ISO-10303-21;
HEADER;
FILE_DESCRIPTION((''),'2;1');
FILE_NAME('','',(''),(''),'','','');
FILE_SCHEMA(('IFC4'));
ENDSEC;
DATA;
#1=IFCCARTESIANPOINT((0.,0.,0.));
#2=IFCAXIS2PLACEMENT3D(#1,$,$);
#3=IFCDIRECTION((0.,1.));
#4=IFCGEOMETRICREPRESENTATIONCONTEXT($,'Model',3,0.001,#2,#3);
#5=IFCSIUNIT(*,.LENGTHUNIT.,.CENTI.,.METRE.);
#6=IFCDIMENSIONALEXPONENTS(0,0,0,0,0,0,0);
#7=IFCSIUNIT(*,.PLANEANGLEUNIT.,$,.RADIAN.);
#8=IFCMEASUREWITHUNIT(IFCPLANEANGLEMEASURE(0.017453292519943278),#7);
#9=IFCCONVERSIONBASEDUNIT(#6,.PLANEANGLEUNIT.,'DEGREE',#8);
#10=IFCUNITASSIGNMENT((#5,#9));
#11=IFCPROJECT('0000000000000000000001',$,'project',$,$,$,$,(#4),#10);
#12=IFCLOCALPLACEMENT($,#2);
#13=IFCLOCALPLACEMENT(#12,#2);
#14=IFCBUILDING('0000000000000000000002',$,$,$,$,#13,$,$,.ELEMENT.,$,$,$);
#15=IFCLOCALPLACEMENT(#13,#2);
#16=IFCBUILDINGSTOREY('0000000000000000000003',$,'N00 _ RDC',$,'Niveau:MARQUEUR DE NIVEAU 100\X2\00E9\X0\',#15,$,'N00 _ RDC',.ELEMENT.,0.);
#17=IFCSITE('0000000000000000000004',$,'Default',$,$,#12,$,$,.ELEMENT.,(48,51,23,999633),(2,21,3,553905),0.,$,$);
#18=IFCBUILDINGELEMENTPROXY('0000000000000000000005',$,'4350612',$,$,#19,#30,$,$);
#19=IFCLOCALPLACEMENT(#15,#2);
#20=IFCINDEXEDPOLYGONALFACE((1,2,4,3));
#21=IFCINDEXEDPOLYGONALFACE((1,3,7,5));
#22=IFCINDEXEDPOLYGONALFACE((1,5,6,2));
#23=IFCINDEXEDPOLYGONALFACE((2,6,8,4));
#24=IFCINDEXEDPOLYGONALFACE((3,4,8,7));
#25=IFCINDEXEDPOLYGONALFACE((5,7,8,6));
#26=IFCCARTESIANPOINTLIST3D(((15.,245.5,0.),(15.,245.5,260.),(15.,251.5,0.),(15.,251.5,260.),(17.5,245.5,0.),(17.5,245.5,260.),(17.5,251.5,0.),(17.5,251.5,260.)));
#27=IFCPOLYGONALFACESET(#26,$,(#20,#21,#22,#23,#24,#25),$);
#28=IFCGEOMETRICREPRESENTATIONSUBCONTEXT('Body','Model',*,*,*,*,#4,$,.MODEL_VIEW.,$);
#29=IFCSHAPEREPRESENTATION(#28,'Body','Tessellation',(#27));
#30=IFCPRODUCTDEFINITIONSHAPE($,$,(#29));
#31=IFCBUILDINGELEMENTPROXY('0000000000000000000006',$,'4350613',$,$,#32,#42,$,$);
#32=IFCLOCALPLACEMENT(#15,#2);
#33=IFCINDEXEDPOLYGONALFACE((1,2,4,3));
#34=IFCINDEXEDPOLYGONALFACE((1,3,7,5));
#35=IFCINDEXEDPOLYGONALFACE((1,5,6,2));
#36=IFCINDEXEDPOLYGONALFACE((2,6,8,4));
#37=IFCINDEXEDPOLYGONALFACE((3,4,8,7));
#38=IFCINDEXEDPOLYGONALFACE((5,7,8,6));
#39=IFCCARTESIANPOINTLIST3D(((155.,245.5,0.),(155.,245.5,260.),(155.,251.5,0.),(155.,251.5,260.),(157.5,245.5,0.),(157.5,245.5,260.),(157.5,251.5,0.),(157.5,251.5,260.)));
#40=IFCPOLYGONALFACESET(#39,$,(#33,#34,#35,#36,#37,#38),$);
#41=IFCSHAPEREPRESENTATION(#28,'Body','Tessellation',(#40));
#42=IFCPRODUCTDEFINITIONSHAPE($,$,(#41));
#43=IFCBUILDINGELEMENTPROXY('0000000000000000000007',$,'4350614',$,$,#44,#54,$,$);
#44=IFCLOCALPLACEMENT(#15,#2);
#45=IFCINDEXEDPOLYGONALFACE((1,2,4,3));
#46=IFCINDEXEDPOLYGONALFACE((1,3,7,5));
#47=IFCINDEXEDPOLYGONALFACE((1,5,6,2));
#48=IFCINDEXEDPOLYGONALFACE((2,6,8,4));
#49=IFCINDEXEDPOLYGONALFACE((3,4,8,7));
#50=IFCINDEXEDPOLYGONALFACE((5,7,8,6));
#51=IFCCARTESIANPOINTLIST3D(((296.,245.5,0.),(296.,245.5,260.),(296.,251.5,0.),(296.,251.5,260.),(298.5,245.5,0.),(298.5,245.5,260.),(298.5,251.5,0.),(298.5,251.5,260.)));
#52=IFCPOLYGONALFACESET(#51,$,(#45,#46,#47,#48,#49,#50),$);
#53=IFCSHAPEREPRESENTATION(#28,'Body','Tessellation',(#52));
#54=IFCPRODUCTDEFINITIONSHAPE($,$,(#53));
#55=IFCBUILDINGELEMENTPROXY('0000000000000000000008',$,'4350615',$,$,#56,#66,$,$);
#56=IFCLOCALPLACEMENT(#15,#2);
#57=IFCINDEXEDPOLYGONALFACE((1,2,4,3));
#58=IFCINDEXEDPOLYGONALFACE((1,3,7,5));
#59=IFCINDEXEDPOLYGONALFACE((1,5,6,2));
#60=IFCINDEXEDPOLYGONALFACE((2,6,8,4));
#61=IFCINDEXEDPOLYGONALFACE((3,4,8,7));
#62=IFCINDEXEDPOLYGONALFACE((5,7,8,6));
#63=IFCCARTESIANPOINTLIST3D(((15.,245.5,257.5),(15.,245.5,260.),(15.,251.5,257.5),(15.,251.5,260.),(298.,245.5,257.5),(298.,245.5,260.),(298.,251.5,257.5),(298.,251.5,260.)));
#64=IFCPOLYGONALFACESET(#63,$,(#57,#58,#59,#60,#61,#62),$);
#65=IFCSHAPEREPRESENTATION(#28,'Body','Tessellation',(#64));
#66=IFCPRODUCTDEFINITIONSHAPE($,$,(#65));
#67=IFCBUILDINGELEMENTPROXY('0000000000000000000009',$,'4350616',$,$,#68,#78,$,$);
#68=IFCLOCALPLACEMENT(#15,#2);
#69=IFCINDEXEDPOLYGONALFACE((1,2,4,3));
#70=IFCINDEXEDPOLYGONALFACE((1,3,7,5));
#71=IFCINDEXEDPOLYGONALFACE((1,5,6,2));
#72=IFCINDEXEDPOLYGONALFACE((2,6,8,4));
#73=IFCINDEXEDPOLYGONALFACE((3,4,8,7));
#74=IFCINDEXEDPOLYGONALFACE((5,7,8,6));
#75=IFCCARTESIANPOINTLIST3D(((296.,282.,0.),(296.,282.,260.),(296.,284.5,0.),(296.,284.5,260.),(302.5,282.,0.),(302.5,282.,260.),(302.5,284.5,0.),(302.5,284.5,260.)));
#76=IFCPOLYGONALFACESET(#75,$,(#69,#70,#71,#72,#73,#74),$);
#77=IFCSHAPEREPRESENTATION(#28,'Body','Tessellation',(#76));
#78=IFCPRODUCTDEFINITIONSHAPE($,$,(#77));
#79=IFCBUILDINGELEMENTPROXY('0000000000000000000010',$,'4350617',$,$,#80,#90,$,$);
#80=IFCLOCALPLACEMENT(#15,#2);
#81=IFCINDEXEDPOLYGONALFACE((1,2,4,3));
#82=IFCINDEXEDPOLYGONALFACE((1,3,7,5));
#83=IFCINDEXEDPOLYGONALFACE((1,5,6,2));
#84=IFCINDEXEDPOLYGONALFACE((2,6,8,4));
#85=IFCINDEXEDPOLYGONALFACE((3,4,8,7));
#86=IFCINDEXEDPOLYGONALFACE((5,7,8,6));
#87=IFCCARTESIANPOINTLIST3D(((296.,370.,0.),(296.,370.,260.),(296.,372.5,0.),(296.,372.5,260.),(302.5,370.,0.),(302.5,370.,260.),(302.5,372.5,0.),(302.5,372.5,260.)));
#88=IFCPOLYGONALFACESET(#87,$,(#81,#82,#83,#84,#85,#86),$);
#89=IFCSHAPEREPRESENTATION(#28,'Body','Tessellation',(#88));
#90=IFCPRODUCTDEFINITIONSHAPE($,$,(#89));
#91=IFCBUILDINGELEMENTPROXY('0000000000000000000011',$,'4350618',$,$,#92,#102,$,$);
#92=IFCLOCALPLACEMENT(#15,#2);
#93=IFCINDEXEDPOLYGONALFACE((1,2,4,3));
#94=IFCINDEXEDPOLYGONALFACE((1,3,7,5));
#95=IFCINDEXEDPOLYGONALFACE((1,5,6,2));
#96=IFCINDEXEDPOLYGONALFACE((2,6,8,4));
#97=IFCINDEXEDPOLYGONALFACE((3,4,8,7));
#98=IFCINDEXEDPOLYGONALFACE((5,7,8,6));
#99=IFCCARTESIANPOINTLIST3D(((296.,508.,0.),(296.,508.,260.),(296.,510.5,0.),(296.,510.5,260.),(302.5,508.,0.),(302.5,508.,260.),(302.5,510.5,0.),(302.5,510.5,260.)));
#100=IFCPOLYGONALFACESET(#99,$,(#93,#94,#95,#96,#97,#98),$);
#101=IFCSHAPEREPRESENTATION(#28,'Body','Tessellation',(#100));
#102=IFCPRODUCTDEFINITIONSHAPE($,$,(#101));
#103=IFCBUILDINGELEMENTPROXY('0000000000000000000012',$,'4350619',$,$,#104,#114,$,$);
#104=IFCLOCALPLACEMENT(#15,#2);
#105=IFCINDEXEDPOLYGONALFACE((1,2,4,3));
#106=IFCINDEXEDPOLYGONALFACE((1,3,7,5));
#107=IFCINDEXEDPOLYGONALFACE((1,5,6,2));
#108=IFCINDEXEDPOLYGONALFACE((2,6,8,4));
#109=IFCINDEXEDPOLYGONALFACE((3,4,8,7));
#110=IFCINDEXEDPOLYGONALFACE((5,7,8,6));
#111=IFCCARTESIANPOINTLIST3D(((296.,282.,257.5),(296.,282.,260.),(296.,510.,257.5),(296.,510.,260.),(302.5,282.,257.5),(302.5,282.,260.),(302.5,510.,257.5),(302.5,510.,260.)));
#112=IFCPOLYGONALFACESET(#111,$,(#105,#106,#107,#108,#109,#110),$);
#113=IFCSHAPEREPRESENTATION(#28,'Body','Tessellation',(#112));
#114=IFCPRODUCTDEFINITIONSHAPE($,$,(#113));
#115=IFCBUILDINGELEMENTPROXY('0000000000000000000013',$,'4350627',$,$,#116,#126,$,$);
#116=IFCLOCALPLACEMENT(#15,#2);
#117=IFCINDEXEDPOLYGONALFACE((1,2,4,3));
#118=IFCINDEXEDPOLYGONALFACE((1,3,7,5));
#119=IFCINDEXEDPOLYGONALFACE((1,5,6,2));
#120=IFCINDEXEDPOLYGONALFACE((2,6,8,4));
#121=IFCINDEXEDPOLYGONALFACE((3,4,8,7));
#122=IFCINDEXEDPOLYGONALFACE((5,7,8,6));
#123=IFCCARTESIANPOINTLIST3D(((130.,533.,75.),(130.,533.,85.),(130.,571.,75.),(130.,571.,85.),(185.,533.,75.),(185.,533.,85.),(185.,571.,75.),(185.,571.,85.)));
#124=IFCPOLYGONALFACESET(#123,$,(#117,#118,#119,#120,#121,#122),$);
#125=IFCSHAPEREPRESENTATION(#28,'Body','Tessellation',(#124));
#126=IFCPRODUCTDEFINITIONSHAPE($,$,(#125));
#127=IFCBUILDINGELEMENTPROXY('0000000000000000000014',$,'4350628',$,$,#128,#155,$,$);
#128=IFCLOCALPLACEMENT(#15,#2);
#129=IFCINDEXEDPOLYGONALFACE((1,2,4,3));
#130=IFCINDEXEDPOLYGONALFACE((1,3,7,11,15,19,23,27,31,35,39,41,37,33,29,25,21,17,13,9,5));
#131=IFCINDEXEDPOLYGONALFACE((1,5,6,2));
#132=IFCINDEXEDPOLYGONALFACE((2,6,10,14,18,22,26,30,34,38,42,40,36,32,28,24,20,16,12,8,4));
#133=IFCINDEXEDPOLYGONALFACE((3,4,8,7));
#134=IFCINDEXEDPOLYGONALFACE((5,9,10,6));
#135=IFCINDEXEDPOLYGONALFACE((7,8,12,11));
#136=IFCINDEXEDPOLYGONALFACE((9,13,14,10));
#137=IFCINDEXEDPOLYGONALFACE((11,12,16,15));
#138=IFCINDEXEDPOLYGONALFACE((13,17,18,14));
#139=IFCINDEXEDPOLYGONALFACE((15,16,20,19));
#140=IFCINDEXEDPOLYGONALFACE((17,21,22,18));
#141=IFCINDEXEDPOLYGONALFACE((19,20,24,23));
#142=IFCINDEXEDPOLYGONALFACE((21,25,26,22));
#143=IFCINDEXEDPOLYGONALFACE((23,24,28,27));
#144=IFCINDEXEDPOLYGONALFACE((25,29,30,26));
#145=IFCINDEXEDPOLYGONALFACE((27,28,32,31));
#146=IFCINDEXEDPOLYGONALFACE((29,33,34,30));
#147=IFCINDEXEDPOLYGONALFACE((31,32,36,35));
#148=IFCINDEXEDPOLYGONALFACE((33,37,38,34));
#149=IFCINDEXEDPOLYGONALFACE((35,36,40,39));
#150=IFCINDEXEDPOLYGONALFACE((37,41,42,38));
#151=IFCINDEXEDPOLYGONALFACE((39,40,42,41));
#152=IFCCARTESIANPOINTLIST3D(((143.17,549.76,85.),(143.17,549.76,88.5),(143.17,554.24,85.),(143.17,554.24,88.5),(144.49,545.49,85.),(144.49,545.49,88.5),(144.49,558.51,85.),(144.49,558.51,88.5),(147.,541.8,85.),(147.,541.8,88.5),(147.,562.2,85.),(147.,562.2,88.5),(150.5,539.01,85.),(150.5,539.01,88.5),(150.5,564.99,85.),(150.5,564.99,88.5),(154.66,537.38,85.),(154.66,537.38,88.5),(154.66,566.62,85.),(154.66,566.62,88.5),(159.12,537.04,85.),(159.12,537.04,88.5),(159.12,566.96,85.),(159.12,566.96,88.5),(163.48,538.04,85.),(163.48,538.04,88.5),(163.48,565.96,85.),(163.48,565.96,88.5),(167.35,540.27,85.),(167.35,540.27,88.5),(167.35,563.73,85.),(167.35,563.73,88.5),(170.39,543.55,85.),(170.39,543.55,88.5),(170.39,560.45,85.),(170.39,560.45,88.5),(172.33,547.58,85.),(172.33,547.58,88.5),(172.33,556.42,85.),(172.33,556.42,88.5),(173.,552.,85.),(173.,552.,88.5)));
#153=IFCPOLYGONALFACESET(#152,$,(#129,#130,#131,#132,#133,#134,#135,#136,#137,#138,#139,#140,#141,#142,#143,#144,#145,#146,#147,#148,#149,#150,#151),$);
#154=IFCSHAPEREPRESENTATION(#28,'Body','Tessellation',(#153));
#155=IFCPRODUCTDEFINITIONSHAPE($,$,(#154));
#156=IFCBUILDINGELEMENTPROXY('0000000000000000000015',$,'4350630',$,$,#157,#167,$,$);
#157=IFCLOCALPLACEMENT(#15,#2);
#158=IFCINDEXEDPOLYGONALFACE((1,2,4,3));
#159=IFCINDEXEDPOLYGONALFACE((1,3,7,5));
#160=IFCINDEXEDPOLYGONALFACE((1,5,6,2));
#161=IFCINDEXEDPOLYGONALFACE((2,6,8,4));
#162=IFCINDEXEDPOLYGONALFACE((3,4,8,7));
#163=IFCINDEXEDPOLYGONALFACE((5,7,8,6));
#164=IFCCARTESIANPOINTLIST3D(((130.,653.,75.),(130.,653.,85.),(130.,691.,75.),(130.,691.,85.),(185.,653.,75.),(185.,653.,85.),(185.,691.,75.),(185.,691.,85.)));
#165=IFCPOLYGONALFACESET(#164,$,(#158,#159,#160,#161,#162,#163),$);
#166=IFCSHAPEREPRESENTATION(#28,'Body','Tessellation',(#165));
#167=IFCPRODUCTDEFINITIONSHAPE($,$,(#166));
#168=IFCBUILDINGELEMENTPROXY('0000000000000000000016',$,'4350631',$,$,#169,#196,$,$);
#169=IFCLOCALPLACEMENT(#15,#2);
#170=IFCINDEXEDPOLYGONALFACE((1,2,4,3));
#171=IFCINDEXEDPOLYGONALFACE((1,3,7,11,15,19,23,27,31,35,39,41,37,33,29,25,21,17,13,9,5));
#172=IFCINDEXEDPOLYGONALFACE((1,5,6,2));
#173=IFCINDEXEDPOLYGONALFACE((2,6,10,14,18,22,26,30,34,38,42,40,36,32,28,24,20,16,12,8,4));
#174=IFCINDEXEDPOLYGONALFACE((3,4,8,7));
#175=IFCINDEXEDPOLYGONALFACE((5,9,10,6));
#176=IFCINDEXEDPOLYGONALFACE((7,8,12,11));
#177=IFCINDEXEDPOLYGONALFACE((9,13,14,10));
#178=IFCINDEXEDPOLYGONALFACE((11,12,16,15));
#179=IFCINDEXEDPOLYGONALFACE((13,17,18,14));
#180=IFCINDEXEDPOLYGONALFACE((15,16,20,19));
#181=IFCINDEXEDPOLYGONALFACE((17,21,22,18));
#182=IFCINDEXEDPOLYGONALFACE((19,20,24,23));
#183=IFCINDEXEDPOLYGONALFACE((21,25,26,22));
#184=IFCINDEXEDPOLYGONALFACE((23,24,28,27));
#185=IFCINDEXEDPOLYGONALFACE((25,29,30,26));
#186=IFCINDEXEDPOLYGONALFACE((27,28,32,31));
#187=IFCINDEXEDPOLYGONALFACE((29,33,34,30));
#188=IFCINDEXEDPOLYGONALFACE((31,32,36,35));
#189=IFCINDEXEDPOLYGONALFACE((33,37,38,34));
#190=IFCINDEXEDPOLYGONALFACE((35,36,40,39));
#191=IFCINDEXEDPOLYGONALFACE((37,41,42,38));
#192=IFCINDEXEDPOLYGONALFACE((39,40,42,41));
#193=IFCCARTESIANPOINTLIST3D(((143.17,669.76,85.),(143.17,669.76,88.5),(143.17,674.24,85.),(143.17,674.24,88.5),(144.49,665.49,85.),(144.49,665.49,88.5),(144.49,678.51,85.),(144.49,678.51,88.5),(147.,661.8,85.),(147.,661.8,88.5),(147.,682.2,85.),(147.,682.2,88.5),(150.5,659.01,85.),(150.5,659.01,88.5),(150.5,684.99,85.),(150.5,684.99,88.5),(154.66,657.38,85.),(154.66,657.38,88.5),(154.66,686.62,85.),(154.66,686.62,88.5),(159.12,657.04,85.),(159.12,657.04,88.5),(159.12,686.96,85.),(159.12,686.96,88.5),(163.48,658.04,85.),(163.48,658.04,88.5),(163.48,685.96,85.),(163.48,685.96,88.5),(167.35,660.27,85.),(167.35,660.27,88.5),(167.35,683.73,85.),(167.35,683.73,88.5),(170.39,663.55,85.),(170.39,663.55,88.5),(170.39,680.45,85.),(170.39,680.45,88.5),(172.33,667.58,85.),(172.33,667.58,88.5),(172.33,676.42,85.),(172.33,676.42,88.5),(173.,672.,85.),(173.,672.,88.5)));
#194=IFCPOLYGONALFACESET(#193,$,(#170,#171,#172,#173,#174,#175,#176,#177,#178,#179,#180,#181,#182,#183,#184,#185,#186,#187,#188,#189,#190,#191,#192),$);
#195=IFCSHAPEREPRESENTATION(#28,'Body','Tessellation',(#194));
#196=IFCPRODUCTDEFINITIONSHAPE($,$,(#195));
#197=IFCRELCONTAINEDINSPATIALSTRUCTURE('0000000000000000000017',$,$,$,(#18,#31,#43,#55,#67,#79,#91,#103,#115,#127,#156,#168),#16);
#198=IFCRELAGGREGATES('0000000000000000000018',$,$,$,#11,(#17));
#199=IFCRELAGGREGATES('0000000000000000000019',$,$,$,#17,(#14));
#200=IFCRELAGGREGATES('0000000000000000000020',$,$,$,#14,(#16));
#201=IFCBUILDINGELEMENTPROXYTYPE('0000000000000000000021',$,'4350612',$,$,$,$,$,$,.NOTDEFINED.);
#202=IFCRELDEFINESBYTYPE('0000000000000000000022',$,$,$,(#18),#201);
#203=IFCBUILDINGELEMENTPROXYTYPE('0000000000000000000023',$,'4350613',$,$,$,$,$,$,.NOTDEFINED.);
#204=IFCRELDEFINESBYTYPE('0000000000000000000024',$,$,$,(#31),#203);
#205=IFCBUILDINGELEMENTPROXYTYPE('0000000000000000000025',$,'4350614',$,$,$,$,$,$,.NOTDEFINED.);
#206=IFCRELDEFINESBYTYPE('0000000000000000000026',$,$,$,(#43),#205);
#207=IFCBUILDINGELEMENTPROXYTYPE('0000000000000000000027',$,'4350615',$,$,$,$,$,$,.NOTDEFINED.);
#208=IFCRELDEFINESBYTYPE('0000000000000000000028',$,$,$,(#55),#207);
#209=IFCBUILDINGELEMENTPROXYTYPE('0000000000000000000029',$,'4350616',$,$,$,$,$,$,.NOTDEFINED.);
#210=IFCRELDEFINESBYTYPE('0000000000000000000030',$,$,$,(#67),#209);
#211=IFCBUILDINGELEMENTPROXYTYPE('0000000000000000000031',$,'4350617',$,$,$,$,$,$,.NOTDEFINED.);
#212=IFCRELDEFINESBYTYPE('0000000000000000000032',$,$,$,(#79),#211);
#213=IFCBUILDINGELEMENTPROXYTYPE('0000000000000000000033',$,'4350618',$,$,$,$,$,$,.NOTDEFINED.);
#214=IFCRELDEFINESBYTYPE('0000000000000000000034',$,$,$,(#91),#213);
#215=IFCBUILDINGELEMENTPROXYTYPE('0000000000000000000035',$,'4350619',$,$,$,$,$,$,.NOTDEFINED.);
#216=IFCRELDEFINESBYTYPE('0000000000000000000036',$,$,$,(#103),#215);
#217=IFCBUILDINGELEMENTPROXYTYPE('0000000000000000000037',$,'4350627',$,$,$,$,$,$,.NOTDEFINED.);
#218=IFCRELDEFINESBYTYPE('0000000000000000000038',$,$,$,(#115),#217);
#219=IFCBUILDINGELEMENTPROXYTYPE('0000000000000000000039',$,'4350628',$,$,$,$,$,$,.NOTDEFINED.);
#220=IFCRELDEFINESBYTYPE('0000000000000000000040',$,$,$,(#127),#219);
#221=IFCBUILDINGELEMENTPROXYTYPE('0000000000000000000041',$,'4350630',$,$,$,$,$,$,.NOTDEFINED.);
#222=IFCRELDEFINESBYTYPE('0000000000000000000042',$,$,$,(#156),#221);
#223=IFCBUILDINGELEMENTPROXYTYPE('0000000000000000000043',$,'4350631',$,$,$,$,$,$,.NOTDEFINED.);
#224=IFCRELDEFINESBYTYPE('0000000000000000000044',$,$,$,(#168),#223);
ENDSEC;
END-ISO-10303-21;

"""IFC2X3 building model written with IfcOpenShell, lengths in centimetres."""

from ifc_helpers import new_model, entity, si_unit, converted_unit, direction, frame, frame_2d, origin, origin_2d_with_axis, place, context, subcontext, project, spatial, rectangle, circle, extrude, type_object, element, save


model = new_model("IFC2X3")

# Units and contexts
model_context = context("Model", 3, precision=0.001, world=origin(), true_north=direction((0.0, 1.0)))
body_context = subcontext(model_context, "Body", "Model", "MODEL_VIEW")
ifc_project = project(units=[si_unit("LENGTHUNIT", "METRE", prefix="CENTI"), converted_unit("PLANEANGLEUNIT", "DEGREE", entity("IfcPlaneAngleMeasure", 0.017453292519943278), si_unit("PLANEANGLEUNIT", "RADIAN"), dimensions=[0, 0, 0, 0, 0, 0, 0])], contexts=[model_context])

# Site, building, storey
site_placement = place(None, origin())
site = spatial("IfcSite", under=ifc_project, at=site_placement, Name="Default", CompositionType="ELEMENT", RefLatitude=(48, 51, 23, 999633), RefLongitude=(2, 21, 3, 553905), RefElevation=0.0)
building_placement = place(site_placement, origin())
building = spatial("IfcBuilding", under=site, at=building_placement, CompositionType="ELEMENT")
storey_placement = place(building_placement, origin())
storey = spatial("IfcBuildingStorey", under=building, at=storey_placement, Name="N00 _ RDC", ObjectType="Niveau:MARQUEUR DE NIVEAU 100é", LongName="N00 _ RDC", CompositionType="ELEMENT", Elevation=0.0)

# Building element proxies
building_element_proxy_type_1 = type_object("IfcBuildingElementProxyType", Name="4350612", PredefinedType="NOTDEFINED")
proxy_1_placement = place(storey_placement, origin())
element("IfcBuildingElementProxy", 1, at=proxy_1_placement, inside=storey, type_object=building_element_proxy_type_1, Name="4350612", context=body_context, shape_type="SweptSolid", body=[
    extrude(rectangle(XDim=2.5, YDim=6.0, at=frame_2d((0.0, 0.0), x_axis=(1.0, 0.0))), frame((16.25, 248.5, 0.0)), (0.0, 0.0, 1.0), 260.0),
])
building_element_proxy_type_2 = type_object("IfcBuildingElementProxyType", Name="4350613", PredefinedType="NOTDEFINED")
proxy_2_placement = place(storey_placement, origin())
element("IfcBuildingElementProxy", 2, at=proxy_2_placement, inside=storey, type_object=building_element_proxy_type_2, Name="4350613", context=body_context, shape_type="SweptSolid", body=[
    extrude(rectangle(XDim=2.5, YDim=6.0, at=frame_2d((0.0, 0.0), x_axis=(1.0, 0.0))), frame((156.25, 248.5, 0.0)), (0.0, 0.0, 1.0), 260.0),
])
building_element_proxy_type_3 = type_object("IfcBuildingElementProxyType", Name="4350614", PredefinedType="NOTDEFINED")
proxy_3_placement = place(storey_placement, origin())
element("IfcBuildingElementProxy", 3, at=proxy_3_placement, inside=storey, type_object=building_element_proxy_type_3, Name="4350614", context=body_context, shape_type="SweptSolid", body=[
    extrude(rectangle(XDim=2.5, YDim=6.0, at=frame_2d((0.0, 0.0), x_axis=(1.0, 0.0))), frame((297.25, 248.5, 0.0)), (0.0, 0.0, 1.0), 260.0),
])
building_element_proxy_type_4 = type_object("IfcBuildingElementProxyType", Name="4350615", PredefinedType="NOTDEFINED")
proxy_4_placement = place(storey_placement, origin())
element("IfcBuildingElementProxy", 4, at=proxy_4_placement, inside=storey, type_object=building_element_proxy_type_4, Name="4350615", context=body_context, shape_type="SweptSolid", body=[
    extrude(rectangle(XDim=283.0, YDim=6.0, at=frame_2d((0.0, 0.0), x_axis=(1.0, 0.0))), frame((156.5, 248.5, 257.5)), (0.0, 0.0, 1.0), 2.5),
])
building_element_proxy_type_5 = type_object("IfcBuildingElementProxyType", Name="4350616", PredefinedType="NOTDEFINED")
proxy_5_placement = place(storey_placement, origin())
element("IfcBuildingElementProxy", 5, at=proxy_5_placement, inside=storey, type_object=building_element_proxy_type_5, Name="4350616", context=body_context, shape_type="SweptSolid", body=[
    extrude(rectangle(XDim=6.5, YDim=2.5, at=frame_2d((0.0, 0.0), x_axis=(1.0, 0.0))), frame((299.25, 283.25, 0.0)), (0.0, 0.0, 1.0), 260.0),
])
building_element_proxy_type_6 = type_object("IfcBuildingElementProxyType", Name="4350617", PredefinedType="NOTDEFINED")
proxy_6_placement = place(storey_placement, origin())
element("IfcBuildingElementProxy", 6, at=proxy_6_placement, inside=storey, type_object=building_element_proxy_type_6, Name="4350617", context=body_context, shape_type="SweptSolid", body=[
    extrude(rectangle(XDim=6.5, YDim=2.5, at=frame_2d((0.0, 0.0), x_axis=(1.0, 0.0))), frame((299.25, 371.25, 0.0)), (0.0, 0.0, 1.0), 260.0),
])
building_element_proxy_type_7 = type_object("IfcBuildingElementProxyType", Name="4350618", PredefinedType="NOTDEFINED")
proxy_7_placement = place(storey_placement, origin())
element("IfcBuildingElementProxy", 7, at=proxy_7_placement, inside=storey, type_object=building_element_proxy_type_7, Name="4350618", context=body_context, shape_type="SweptSolid", body=[
    extrude(rectangle(XDim=6.5, YDim=2.5, at=frame_2d((0.0, 0.0), x_axis=(1.0, 0.0))), frame((299.25, 509.25, 0.0)), (0.0, 0.0, 1.0), 260.0),
])
building_element_proxy_type_8 = type_object("IfcBuildingElementProxyType", Name="4350619", PredefinedType="NOTDEFINED")
proxy_8_placement = place(storey_placement, origin())
element("IfcBuildingElementProxy", 8, at=proxy_8_placement, inside=storey, type_object=building_element_proxy_type_8, Name="4350619", context=body_context, shape_type="SweptSolid", body=[
    extrude(rectangle(XDim=6.5, YDim=228.0, at=frame_2d((0.0, 0.0), x_axis=(1.0, 0.0))), frame((299.25, 396.0, 257.5)), (0.0, 0.0, 1.0), 2.5),
])
building_element_proxy_type_9 = type_object("IfcBuildingElementProxyType", Name="4350627", PredefinedType="NOTDEFINED")
proxy_9_placement = place(storey_placement, origin())
element("IfcBuildingElementProxy", 9, at=proxy_9_placement, inside=storey, type_object=building_element_proxy_type_9, Name="4350627", context=body_context, shape_type="SweptSolid", body=[
    extrude(rectangle(XDim=55.0, YDim=38.0, at=origin_2d_with_axis()), frame((157.5, 552.0, 75.0)), (0.0, 0.0, 1.0), 10.0),
])
building_element_proxy_type_10 = type_object("IfcBuildingElementProxyType", Name="4350628", PredefinedType="NOTDEFINED")
proxy_10_placement = place(storey_placement, origin())
element("IfcBuildingElementProxy", 10, at=proxy_10_placement, inside=storey, type_object=building_element_proxy_type_10, Name="4350628", context=body_context, shape_type="SweptSolid", body=[
    extrude(circle(Radius=15.0, at=origin_2d_with_axis()), frame((158.0, 552.0, 85.0)), (0.0, 0.0, 1.0), 3.5),
])
building_element_proxy_type_11 = type_object("IfcBuildingElementProxyType", Name="4350630", PredefinedType="NOTDEFINED")
proxy_11_placement = place(storey_placement, origin())
element("IfcBuildingElementProxy", 11, at=proxy_11_placement, inside=storey, type_object=building_element_proxy_type_11, Name="4350630", context=body_context, shape_type="SweptSolid", body=[
    extrude(rectangle(XDim=55.0, YDim=38.0, at=origin_2d_with_axis()), frame((157.5, 672.0, 75.0)), (0.0, 0.0, 1.0), 10.0),
])
building_element_proxy_type_12 = type_object("IfcBuildingElementProxyType", Name="4350631", PredefinedType="NOTDEFINED")
proxy_12_placement = place(storey_placement, origin())
element("IfcBuildingElementProxy", 12, at=proxy_12_placement, inside=storey, type_object=building_element_proxy_type_12, Name="4350631", context=body_context, shape_type="SweptSolid", body=[
    extrude(circle(Radius=15.0, at=origin_2d_with_axis()), frame((158.0, 672.0, 85.0)), (0.0, 0.0, 1.0), 3.5),
])

save(model, "model.ifc")
